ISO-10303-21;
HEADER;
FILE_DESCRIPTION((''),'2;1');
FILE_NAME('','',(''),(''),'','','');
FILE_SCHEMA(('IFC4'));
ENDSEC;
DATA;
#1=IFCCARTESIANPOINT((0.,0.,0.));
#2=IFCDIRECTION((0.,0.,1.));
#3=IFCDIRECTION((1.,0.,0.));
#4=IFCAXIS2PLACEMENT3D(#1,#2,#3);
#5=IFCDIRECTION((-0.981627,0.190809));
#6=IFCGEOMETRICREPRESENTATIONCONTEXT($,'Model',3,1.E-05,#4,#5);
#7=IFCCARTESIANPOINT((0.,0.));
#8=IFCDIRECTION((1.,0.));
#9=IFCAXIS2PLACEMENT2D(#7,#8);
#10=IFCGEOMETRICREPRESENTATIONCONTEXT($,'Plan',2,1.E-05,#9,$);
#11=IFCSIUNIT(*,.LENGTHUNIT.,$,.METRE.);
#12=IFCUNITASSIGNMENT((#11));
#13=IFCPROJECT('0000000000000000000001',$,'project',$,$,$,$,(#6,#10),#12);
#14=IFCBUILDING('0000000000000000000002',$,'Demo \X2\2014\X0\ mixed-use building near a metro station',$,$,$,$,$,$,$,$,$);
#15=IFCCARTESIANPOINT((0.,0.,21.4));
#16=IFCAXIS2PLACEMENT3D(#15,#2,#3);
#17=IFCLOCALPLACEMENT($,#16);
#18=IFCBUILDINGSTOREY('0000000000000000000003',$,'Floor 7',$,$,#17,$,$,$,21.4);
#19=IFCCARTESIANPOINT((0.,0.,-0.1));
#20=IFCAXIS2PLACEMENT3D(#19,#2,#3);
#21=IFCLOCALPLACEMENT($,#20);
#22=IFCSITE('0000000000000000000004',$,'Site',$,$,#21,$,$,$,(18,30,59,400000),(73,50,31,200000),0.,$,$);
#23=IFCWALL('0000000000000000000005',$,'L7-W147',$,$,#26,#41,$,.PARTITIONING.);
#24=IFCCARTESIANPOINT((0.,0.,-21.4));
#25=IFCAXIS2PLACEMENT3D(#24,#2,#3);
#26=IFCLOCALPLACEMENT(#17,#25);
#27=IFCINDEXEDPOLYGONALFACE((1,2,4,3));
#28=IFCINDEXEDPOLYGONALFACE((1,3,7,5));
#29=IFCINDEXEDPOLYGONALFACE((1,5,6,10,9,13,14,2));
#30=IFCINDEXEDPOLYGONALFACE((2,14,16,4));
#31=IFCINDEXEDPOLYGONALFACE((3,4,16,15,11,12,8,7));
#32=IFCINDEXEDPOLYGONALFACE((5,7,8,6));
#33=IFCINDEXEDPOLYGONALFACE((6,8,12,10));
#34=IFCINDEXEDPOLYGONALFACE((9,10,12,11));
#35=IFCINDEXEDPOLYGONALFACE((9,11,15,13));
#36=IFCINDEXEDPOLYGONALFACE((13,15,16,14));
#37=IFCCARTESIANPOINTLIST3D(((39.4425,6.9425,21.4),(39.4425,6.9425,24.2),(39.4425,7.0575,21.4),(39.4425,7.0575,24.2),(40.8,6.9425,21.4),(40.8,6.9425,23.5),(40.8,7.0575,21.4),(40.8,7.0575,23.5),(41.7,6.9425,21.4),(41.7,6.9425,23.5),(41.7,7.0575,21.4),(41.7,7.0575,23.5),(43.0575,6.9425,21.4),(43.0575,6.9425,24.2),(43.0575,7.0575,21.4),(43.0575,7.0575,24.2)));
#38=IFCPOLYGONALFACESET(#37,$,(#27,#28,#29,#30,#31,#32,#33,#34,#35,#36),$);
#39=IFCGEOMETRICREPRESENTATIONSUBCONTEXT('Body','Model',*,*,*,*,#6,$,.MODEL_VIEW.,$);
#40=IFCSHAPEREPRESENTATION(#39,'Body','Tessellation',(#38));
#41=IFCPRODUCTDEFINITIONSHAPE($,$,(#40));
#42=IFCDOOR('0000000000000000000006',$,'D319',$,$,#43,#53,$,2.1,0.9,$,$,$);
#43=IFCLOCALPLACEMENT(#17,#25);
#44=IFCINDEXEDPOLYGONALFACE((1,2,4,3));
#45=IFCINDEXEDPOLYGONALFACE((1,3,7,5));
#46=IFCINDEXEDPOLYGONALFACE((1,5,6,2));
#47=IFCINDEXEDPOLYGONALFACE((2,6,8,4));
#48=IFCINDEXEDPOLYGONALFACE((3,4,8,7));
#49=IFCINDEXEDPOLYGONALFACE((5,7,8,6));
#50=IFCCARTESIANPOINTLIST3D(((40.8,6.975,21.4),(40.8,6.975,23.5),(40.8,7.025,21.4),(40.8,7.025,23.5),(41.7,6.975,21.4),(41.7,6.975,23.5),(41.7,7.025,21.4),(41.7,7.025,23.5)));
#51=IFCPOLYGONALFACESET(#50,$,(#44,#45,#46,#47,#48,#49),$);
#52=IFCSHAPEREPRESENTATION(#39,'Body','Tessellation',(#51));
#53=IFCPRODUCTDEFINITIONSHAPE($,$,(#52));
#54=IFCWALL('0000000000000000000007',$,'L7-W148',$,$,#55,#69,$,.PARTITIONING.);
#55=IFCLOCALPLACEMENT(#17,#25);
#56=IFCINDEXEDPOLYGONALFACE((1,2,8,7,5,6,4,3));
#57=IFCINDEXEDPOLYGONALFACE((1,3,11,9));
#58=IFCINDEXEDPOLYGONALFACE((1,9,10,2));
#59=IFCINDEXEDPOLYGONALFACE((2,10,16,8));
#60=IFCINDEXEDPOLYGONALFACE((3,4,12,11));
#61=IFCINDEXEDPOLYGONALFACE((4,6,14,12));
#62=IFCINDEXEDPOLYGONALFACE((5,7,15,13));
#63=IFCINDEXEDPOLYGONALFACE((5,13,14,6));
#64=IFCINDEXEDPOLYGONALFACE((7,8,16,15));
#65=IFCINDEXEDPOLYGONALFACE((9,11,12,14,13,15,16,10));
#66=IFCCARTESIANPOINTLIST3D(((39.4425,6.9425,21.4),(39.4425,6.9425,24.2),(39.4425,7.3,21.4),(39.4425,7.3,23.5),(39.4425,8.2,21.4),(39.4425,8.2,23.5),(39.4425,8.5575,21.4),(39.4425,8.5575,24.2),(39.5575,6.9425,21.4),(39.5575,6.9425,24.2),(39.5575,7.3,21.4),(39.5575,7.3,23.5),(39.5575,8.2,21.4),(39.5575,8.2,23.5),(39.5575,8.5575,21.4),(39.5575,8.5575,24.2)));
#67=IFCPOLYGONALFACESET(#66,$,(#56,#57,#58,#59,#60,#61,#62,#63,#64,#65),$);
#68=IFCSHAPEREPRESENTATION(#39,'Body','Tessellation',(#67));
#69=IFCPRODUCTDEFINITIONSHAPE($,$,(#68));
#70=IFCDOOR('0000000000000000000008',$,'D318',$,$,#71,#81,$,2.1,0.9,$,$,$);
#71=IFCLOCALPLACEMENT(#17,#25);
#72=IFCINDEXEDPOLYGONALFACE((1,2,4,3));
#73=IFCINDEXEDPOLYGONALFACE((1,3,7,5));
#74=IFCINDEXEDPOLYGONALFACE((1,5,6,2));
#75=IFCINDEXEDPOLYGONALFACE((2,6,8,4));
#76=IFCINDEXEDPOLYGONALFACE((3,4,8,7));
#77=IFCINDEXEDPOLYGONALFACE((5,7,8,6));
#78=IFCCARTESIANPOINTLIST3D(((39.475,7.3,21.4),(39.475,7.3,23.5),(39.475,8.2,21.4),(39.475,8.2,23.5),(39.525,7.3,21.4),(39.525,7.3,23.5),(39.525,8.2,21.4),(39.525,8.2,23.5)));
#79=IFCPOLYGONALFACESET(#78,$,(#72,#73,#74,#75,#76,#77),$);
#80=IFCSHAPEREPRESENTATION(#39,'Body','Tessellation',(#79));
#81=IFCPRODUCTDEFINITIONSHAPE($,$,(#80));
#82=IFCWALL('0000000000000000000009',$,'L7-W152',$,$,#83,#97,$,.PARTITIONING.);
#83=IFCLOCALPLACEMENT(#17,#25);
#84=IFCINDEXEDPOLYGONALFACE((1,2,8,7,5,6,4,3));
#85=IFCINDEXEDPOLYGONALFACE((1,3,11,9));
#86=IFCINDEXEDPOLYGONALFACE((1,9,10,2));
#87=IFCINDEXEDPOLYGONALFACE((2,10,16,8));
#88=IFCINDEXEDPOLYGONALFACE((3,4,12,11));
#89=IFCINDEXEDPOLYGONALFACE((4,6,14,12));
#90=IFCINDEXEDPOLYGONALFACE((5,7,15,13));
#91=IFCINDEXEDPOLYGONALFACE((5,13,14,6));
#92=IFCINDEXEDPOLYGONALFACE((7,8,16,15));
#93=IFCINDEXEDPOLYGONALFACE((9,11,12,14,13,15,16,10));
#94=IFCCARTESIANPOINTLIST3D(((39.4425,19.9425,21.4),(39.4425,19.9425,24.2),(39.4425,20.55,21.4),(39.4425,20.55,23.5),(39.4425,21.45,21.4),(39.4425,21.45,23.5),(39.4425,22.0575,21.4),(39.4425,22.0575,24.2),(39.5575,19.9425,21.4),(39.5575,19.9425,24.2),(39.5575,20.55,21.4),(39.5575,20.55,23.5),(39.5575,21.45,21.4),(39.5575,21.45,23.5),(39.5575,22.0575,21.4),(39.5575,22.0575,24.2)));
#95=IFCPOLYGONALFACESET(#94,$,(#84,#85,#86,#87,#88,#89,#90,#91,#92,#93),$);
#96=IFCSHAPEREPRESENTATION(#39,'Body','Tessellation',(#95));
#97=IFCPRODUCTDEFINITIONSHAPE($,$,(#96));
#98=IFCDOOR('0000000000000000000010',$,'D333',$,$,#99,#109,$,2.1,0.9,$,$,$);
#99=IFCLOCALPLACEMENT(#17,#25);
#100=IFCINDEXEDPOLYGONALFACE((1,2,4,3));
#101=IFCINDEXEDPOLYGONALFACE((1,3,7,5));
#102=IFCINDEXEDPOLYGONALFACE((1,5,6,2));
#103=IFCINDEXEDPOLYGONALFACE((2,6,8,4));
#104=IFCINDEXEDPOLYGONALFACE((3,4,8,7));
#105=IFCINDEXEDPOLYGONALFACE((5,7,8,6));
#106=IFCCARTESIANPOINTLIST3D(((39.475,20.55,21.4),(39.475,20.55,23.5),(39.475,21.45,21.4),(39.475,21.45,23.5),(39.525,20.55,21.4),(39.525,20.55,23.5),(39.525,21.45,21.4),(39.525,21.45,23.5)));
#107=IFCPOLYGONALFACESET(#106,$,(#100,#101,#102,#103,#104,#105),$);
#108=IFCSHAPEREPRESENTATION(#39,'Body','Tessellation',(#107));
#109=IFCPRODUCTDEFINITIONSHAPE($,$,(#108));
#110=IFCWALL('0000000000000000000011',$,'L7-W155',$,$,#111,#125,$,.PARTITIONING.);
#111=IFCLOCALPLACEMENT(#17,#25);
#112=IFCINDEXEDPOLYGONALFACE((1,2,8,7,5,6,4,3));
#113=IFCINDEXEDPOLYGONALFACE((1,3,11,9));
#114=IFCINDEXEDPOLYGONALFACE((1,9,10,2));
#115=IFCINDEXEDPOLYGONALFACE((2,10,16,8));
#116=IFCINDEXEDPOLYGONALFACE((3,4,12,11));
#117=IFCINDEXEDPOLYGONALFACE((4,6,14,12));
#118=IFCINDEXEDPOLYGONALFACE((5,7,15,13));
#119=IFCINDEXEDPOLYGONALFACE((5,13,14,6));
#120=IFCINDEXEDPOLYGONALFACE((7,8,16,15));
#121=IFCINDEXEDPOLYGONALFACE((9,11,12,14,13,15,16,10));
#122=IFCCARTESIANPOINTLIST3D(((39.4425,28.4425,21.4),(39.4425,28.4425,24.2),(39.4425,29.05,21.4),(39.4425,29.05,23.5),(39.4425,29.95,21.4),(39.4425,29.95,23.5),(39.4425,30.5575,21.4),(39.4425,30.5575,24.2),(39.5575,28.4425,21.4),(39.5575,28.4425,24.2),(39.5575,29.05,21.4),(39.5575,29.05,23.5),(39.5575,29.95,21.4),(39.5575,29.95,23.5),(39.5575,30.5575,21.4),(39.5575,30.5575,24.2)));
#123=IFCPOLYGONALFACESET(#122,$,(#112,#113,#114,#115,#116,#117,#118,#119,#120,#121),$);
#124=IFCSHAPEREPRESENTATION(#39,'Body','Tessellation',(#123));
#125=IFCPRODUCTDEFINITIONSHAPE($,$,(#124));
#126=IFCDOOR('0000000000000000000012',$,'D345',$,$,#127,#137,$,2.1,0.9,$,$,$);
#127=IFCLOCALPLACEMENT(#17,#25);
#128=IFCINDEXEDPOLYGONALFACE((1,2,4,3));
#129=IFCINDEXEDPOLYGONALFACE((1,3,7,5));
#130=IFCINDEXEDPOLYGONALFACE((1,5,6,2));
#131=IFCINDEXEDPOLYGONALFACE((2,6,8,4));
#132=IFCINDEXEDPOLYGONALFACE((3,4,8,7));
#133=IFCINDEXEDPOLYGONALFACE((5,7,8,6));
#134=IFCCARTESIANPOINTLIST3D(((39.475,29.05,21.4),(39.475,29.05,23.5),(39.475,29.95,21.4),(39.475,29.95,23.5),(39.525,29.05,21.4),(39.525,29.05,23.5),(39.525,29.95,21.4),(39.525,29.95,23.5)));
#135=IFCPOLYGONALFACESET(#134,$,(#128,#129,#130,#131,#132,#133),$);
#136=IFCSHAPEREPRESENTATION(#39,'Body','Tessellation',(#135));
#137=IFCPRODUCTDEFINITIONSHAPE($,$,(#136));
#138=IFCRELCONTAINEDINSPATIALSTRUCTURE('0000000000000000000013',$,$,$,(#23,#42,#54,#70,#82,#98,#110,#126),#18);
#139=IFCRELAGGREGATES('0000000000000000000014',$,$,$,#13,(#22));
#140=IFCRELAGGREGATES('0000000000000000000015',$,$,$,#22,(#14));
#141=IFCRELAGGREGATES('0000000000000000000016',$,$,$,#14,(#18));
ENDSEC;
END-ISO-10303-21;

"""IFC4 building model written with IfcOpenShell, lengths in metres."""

from ifc_helpers import new_model, si_unit, direction, frame, origin_with_axes, origin_2d_with_axis, place, context, subcontext, project, spatial, line, indexed_curve, outline, extrude, element, fill, save


model = new_model("IFC4")

# Units and contexts
model_context = context("Model", 3, precision=1e-05, world=origin_with_axes(), true_north=direction((-0.981627, 0.190809)))
plan_context = context("Plan", 2, precision=1e-05, world=origin_2d_with_axis())
body_context = subcontext(model_context, "Body", "Model", "MODEL_VIEW")
ifc_project = project(units=[si_unit("LENGTHUNIT", "METRE")], contexts=[model_context, plan_context])

# Site, building, storey
site_placement = place(None, frame((0.0, 0.0, -0.1), z_axis=(0.0, 0.0, 1.0), x_axis=(1.0, 0.0, 0.0)))
site = spatial("IfcSite", under=ifc_project, at=site_placement, Name="Site", RefLatitude=(18, 30, 59, 400000), RefLongitude=(73, 50, 31, 200000), RefElevation=0.0)
building = spatial("IfcBuilding", under=site, Name="Demo — mixed-use building near a metro station")
storey_placement = place(None, frame((0.0, 0.0, 21.4), z_axis=(0.0, 0.0, 1.0), x_axis=(1.0, 0.0, 0.0)))
storey = spatial("IfcBuildingStorey", under=building, at=storey_placement, Name="Floor 7", Elevation=21.4)

# Walls, openings, doors
wall_1_placement = place(storey_placement, frame((0.0, 0.0, -21.4), z_axis=(0.0, 0.0, 1.0), x_axis=(1.0, 0.0, 0.0)))
wall_1 = element("IfcWall", 1, at=wall_1_placement, inside=storey, Name="L7-W147", PredefinedType="PARTITIONING", context=body_context, shape_type="SweptSolid", body=[
    extrude(outline(indexed_curve([(43.0575, 6.9425), (39.4425, 6.9425), (39.4425, 7.0575), (43.0575, 7.0575)], segments=[line(1, 2, 3, 4, 1)])), frame((0.0, 0.0, 21.4), z_axis=(0.0, 0.0, 1.0), x_axis=(1.0, 0.0, 0.0)), (0.0, 0.0, 1.0), 2.8),
])
opening_1_placement = place(wall_1_placement, origin_with_axes())
opening_1 = element("IfcOpeningElement", 2, at=opening_1_placement, cuts=wall_1, context=body_context, shape_type="SweptSolid", body=[
    extrude(outline(indexed_curve([(41.7, 6.8925), (40.8, 6.8925), (40.8, 7.1075), (41.7, 7.1075)], segments=[line(1, 2, 3, 4, 1)])), frame((0.0, 0.0, 21.4), z_axis=(0.0, 0.0, 1.0), x_axis=(1.0, 0.0, 0.0)), (0.0, 0.0, 1.0), 2.1),
])
door_1_placement = place(storey_placement, frame((0.0, 0.0, -21.4), z_axis=(0.0, 0.0, 1.0), x_axis=(1.0, 0.0, 0.0)))
door_1 = element("IfcDoor", 3, at=door_1_placement, inside=storey, Name="D319", OverallHeight=2.1, OverallWidth=0.9, context=body_context, shape_type="SweptSolid", body=[
    extrude(outline(indexed_curve([(41.7, 6.975), (40.8, 6.975), (40.8, 7.025), (41.7, 7.025)], segments=[line(1, 2, 3, 4, 1)])), frame((0.0, 0.0, 21.4), z_axis=(0.0, 0.0, 1.0), x_axis=(1.0, 0.0, 0.0)), (0.0, 0.0, 1.0), 2.1),
])
fill(opening_1, door_1)
wall_2_placement = place(storey_placement, frame((0.0, 0.0, -21.4), z_axis=(0.0, 0.0, 1.0), x_axis=(1.0, 0.0, 0.0)))
wall_2 = element("IfcWall", 4, at=wall_2_placement, inside=storey, Name="L7-W148", PredefinedType="PARTITIONING", context=body_context, shape_type="SweptSolid", body=[
    extrude(outline(indexed_curve([(39.5575, 8.5575), (39.5575, 6.9425), (39.4425, 6.9425), (39.4425, 8.5575)], segments=[line(1, 2, 3, 4, 1)])), frame((0.0, 0.0, 21.4), z_axis=(0.0, 0.0, 1.0), x_axis=(1.0, 0.0, 0.0)), (0.0, 0.0, 1.0), 2.8),
])
opening_2_placement = place(wall_2_placement, origin_with_axes())
opening_2 = element("IfcOpeningElement", 5, at=opening_2_placement, cuts=wall_2, context=body_context, shape_type="SweptSolid", body=[
    extrude(outline(indexed_curve([(39.6075, 8.2), (39.6075, 7.3), (39.3925, 7.3), (39.3925, 8.2)], segments=[line(1, 2, 3, 4, 1)])), frame((0.0, 0.0, 21.4), z_axis=(0.0, 0.0, 1.0), x_axis=(1.0, 0.0, 0.0)), (0.0, 0.0, 1.0), 2.1),
])
door_2_placement = place(storey_placement, frame((0.0, 0.0, -21.4), z_axis=(0.0, 0.0, 1.0), x_axis=(1.0, 0.0, 0.0)))
door_2 = element("IfcDoor", 6, at=door_2_placement, inside=storey, Name="D318", OverallHeight=2.1, OverallWidth=0.9, context=body_context, shape_type="SweptSolid", body=[
    extrude(outline(indexed_curve([(39.525, 8.2), (39.525, 7.3), (39.475, 7.3), (39.475, 8.2)], segments=[line(1, 2, 3, 4, 1)])), frame((0.0, 0.0, 21.4), z_axis=(0.0, 0.0, 1.0), x_axis=(1.0, 0.0, 0.0)), (0.0, 0.0, 1.0), 2.1),
])
fill(opening_2, door_2)

# Wall, opening, door
wall_3_placement = place(storey_placement, frame((0.0, 0.0, -21.4), z_axis=(0.0, 0.0, 1.0), x_axis=(1.0, 0.0, 0.0)))
wall_3 = element("IfcWall", 7, at=wall_3_placement, inside=storey, Name="L7-W152", PredefinedType="PARTITIONING", context=body_context, shape_type="SweptSolid", body=[
    extrude(outline(indexed_curve([(39.5575, 22.0575), (39.5575, 19.9425), (39.4425, 19.9425), (39.4425, 22.0575)], segments=[line(1, 2, 3, 4, 1)])), frame((0.0, 0.0, 21.4), z_axis=(0.0, 0.0, 1.0), x_axis=(1.0, 0.0, 0.0)), (0.0, 0.0, 1.0), 2.8),
])
opening_3_placement = place(wall_3_placement, origin_with_axes())
opening_3 = element("IfcOpeningElement", 8, at=opening_3_placement, cuts=wall_3, context=body_context, shape_type="SweptSolid", body=[
    extrude(outline(indexed_curve([(39.6075, 21.45), (39.6075, 20.55), (39.3925, 20.55), (39.3925, 21.45)], segments=[line(1, 2, 3, 4, 1)])), frame((0.0, 0.0, 21.4), z_axis=(0.0, 0.0, 1.0), x_axis=(1.0, 0.0, 0.0)), (0.0, 0.0, 1.0), 2.1),
])
door_3_placement = place(storey_placement, frame((0.0, 0.0, -21.4), z_axis=(0.0, 0.0, 1.0), x_axis=(1.0, 0.0, 0.0)))
door_3 = element("IfcDoor", 9, at=door_3_placement, inside=storey, Name="D333", OverallHeight=2.1, OverallWidth=0.9, context=body_context, shape_type="SweptSolid", body=[
    extrude(outline(indexed_curve([(39.525, 21.45), (39.525, 20.55), (39.475, 20.55), (39.475, 21.45)], segments=[line(1, 2, 3, 4, 1)])), frame((0.0, 0.0, 21.4), z_axis=(0.0, 0.0, 1.0), x_axis=(1.0, 0.0, 0.0)), (0.0, 0.0, 1.0), 2.1),
])
fill(opening_3, door_3)

# Wall, opening, door
wall_4_placement = place(storey_placement, frame((0.0, 0.0, -21.4), z_axis=(0.0, 0.0, 1.0), x_axis=(1.0, 0.0, 0.0)))
wall_4 = element("IfcWall", 10, at=wall_4_placement, inside=storey, Name="L7-W155", PredefinedType="PARTITIONING", context=body_context, shape_type="SweptSolid", body=[
    extrude(outline(indexed_curve([(39.5575, 30.5575), (39.5575, 28.4425), (39.4425, 28.4425), (39.4425, 30.5575)], segments=[line(1, 2, 3, 4, 1)])), frame((0.0, 0.0, 21.4), z_axis=(0.0, 0.0, 1.0), x_axis=(1.0, 0.0, 0.0)), (0.0, 0.0, 1.0), 2.8),
])
opening_4_placement = place(wall_4_placement, origin_with_axes())
opening_4 = element("IfcOpeningElement", 11, at=opening_4_placement, cuts=wall_4, context=body_context, shape_type="SweptSolid", body=[
    extrude(outline(indexed_curve([(39.6075, 29.95), (39.6075, 29.05), (39.3925, 29.05), (39.3925, 29.95)], segments=[line(1, 2, 3, 4, 1)])), frame((0.0, 0.0, 21.4), z_axis=(0.0, 0.0, 1.0), x_axis=(1.0, 0.0, 0.0)), (0.0, 0.0, 1.0), 2.1),
])
door_4_placement = place(storey_placement, frame((0.0, 0.0, -21.4), z_axis=(0.0, 0.0, 1.0), x_axis=(1.0, 0.0, 0.0)))
door_4 = element("IfcDoor", 12, at=door_4_placement, inside=storey, Name="D345", OverallHeight=2.1, OverallWidth=0.9, context=body_context, shape_type="SweptSolid", body=[
    extrude(outline(indexed_curve([(39.525, 29.95), (39.525, 29.05), (39.475, 29.05), (39.475, 29.95)], segments=[line(1, 2, 3, 4, 1)])), frame((0.0, 0.0, 21.4), z_axis=(0.0, 0.0, 1.0), x_axis=(1.0, 0.0, 0.0)), (0.0, 0.0, 1.0), 2.1),
])
fill(opening_4, door_4)

save(model, "model.ifc")
